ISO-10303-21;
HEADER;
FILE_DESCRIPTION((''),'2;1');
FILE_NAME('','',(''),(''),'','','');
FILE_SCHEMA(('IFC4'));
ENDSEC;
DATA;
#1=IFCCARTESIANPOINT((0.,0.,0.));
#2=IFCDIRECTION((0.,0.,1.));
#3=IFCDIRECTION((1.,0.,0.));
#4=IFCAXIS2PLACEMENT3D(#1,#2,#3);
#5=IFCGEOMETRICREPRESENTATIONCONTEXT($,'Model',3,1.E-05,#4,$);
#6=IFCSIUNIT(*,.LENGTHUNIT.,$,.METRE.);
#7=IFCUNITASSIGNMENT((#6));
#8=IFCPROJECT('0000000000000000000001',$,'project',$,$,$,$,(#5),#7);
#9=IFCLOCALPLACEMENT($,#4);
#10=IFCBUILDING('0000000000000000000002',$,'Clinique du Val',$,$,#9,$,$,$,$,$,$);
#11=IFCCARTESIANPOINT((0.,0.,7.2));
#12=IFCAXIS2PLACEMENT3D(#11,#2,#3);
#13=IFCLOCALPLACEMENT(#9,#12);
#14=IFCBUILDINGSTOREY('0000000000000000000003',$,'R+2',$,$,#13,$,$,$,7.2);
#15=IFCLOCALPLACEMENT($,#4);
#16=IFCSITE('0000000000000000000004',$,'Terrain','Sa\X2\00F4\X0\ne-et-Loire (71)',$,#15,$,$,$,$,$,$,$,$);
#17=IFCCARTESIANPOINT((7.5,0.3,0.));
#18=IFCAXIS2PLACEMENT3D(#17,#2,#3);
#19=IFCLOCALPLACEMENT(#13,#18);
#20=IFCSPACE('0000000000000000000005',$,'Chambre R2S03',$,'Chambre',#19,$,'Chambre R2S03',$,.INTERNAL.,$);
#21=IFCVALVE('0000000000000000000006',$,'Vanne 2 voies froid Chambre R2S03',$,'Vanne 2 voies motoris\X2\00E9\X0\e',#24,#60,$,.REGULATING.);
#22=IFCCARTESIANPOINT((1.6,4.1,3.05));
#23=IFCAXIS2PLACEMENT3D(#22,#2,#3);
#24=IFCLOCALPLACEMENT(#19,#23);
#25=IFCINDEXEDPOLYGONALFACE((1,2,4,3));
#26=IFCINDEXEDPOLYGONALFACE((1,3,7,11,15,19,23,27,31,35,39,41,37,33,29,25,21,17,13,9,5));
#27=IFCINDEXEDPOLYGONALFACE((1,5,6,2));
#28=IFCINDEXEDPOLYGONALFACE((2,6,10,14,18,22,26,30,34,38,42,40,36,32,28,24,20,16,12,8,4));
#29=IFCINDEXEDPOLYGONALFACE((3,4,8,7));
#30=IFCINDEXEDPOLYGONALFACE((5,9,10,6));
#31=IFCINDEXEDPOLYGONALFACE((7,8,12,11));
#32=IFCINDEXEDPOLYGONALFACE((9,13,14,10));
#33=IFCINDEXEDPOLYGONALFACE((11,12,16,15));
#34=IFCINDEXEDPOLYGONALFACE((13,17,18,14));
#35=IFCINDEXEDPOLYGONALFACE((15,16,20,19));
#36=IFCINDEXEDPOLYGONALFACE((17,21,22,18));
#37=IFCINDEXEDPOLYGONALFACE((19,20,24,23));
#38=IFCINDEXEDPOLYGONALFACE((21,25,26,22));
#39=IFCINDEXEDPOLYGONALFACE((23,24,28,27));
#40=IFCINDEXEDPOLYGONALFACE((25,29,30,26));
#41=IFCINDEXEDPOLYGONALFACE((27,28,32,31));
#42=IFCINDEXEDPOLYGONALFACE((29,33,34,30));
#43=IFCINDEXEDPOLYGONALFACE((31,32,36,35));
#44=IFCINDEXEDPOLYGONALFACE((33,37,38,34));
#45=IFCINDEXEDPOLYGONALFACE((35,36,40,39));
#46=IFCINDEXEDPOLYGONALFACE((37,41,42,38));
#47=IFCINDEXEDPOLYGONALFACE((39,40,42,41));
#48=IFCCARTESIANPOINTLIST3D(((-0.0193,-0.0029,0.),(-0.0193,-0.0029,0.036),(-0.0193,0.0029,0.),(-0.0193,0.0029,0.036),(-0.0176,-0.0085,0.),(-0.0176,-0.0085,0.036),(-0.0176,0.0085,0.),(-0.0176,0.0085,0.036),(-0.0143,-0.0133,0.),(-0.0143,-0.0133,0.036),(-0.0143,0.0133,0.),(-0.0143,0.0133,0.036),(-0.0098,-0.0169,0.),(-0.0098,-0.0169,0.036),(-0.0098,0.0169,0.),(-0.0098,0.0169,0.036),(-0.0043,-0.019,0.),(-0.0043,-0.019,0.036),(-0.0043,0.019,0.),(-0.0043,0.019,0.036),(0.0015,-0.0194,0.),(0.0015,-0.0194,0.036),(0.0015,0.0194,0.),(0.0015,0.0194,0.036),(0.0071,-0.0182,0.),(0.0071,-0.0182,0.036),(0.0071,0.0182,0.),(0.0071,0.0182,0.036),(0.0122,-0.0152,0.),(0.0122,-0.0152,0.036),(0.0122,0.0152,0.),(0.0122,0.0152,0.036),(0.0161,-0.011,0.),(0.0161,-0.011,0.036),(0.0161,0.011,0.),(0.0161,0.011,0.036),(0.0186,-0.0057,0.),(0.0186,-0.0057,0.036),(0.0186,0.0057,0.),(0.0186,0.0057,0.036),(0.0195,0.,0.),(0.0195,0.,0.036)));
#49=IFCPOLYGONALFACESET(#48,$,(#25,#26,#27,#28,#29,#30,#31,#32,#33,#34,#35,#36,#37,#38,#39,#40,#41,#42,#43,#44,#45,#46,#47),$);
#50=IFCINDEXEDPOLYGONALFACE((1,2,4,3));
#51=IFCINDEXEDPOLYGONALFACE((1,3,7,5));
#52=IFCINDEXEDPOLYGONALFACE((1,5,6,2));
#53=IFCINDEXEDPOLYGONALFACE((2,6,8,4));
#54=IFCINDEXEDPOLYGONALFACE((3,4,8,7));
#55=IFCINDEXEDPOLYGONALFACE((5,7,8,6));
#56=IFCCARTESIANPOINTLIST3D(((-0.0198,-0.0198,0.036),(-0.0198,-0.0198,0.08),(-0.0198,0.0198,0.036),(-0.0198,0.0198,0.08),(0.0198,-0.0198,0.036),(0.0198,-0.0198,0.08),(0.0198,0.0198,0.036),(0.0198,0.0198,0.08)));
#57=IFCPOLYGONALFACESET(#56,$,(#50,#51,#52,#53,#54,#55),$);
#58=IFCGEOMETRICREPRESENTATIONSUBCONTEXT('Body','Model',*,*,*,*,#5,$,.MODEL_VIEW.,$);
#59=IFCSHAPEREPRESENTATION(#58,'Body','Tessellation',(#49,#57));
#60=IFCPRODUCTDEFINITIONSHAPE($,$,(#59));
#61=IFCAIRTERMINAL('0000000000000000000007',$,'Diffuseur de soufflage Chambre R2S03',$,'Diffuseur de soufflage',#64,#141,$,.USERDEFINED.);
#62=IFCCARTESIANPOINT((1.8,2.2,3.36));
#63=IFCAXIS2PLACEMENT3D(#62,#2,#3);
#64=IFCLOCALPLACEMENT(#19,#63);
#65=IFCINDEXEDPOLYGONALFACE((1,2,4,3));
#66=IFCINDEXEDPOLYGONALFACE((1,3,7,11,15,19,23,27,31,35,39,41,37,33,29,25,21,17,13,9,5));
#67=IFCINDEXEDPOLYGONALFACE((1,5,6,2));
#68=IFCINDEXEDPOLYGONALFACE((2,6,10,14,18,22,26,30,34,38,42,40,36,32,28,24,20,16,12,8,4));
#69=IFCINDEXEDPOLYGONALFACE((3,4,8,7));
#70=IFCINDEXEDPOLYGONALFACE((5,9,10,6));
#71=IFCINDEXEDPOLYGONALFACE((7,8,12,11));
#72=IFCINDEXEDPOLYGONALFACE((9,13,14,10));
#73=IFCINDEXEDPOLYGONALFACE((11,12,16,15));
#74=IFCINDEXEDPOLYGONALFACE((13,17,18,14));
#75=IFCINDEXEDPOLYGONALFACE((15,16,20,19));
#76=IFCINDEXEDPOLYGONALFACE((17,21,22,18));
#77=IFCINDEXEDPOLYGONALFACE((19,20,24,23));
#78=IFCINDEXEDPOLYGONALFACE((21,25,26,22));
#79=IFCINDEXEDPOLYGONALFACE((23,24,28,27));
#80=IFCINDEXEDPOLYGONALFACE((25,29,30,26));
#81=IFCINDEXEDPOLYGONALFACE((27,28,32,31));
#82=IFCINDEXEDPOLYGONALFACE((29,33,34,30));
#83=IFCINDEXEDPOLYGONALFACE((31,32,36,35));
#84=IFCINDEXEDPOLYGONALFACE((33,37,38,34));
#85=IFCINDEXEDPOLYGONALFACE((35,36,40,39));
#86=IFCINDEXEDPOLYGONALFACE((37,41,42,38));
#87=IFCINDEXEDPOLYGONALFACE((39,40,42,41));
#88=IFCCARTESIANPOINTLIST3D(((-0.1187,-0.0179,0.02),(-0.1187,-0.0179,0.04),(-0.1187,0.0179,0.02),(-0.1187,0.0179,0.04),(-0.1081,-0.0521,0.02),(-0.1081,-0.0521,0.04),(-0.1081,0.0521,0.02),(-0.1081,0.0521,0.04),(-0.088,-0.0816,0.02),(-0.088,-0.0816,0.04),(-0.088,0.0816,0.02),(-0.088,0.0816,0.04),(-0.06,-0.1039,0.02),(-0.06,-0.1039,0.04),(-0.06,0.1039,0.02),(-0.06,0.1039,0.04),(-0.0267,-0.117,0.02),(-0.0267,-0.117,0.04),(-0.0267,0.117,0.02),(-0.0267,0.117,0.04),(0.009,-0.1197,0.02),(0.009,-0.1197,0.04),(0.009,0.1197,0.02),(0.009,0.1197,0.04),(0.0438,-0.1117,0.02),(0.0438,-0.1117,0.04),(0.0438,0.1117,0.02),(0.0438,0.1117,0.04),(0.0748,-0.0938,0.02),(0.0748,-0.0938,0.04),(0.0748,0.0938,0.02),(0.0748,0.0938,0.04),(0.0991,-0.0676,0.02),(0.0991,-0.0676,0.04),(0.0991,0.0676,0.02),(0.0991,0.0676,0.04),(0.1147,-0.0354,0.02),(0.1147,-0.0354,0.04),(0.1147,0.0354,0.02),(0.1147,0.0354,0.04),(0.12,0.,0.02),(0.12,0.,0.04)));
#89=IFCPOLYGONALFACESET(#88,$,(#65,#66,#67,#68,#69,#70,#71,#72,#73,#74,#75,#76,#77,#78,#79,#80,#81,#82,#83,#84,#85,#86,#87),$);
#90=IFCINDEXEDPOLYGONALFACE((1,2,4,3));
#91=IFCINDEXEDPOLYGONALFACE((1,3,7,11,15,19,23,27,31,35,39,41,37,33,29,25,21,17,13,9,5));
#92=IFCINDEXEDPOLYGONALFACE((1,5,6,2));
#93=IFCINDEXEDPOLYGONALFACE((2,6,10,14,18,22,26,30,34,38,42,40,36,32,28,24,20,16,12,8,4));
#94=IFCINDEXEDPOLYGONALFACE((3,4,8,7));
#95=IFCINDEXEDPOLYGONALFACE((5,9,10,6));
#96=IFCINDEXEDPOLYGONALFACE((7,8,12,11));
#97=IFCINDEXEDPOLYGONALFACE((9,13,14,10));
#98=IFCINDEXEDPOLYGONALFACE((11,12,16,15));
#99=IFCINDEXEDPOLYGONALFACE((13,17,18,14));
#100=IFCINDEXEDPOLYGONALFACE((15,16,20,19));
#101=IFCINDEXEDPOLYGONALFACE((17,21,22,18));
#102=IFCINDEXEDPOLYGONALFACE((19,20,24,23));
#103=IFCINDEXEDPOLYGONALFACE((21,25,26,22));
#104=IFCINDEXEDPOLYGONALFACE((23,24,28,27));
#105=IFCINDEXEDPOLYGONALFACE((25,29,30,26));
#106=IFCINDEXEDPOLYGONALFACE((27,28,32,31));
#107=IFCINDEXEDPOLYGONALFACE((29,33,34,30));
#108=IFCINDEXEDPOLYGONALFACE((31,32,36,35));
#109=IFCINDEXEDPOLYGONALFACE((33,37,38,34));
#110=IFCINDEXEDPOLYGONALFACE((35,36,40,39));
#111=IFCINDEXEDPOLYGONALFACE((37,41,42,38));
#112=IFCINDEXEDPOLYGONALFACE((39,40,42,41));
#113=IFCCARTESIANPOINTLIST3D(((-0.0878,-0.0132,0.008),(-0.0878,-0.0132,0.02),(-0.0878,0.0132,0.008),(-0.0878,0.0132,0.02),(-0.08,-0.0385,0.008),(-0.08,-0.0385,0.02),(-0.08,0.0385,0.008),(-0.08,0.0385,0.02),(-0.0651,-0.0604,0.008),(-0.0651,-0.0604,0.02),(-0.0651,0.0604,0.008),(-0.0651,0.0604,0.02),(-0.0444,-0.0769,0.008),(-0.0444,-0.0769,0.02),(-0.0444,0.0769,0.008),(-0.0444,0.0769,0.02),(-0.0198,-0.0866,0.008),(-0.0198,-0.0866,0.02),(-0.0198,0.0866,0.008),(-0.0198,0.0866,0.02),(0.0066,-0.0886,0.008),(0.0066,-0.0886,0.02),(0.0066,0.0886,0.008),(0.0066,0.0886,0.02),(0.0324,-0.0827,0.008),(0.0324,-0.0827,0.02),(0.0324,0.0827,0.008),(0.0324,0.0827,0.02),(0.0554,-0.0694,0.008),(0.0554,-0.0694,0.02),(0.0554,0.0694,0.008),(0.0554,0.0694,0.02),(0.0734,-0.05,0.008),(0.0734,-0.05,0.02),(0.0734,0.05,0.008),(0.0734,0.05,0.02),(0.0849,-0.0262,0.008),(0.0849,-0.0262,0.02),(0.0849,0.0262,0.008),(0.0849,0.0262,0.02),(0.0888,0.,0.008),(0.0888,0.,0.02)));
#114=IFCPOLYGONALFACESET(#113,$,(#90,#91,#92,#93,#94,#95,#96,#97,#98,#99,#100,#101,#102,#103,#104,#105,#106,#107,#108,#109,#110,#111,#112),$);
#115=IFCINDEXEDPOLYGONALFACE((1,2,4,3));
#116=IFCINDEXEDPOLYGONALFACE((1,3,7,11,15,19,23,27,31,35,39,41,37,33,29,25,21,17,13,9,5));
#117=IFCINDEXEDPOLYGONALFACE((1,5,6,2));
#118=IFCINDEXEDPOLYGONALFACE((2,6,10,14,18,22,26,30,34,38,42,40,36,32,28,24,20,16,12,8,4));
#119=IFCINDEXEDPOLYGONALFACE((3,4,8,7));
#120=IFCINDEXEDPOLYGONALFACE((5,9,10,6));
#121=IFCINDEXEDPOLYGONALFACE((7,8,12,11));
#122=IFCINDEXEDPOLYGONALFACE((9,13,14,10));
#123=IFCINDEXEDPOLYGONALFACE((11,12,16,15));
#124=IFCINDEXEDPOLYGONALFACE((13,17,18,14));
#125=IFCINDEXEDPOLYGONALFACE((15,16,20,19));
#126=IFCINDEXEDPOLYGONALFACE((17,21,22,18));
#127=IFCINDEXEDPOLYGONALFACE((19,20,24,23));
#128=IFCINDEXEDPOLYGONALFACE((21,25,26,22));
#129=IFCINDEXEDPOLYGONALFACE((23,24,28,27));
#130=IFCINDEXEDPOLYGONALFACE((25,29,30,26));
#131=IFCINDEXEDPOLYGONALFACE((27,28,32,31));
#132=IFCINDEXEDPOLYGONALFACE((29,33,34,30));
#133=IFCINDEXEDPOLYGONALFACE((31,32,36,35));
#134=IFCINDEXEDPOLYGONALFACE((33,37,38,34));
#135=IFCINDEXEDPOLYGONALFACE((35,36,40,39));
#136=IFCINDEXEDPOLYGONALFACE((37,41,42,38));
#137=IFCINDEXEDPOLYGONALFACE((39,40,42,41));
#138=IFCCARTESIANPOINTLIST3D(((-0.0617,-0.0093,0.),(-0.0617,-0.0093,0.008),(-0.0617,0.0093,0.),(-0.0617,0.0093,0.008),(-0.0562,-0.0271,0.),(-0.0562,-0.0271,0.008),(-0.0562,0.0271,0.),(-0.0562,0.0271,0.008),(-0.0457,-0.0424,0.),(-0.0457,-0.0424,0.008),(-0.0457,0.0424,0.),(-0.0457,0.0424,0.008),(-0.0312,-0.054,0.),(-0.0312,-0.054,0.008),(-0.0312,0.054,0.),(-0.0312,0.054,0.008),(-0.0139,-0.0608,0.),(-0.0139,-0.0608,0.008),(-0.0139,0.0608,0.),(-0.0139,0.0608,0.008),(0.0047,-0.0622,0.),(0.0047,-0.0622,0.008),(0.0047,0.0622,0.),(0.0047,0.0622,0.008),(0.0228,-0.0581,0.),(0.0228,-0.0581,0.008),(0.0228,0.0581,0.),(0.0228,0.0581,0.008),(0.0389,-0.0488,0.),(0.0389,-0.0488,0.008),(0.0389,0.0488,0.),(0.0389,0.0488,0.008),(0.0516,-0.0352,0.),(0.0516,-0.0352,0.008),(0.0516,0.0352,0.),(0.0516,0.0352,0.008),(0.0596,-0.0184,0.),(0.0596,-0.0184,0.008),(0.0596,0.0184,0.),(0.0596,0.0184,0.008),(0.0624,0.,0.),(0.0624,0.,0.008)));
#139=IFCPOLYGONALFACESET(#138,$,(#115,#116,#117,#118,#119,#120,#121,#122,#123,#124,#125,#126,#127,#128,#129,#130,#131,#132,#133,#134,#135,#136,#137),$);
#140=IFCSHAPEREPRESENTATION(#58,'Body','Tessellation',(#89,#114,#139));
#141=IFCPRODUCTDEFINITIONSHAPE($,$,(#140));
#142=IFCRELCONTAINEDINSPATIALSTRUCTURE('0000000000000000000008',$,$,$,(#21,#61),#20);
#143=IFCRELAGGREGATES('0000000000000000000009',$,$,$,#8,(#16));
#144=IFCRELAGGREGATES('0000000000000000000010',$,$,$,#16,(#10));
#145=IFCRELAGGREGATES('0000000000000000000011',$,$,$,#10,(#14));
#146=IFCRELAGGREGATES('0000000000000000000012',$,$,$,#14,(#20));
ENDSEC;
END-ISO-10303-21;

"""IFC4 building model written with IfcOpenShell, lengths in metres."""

from ifc_helpers import new_model, si_unit, frame, frame_2d, origin_with_axes, place, context, subcontext, project, spatial, rectangle, circle, extrude, element, save


model = new_model("IFC4")

# Units and contexts
model_context = context("Model", 3, precision=1e-05, world=origin_with_axes())
body_context = subcontext(model_context, "Body", "Model", "MODEL_VIEW")
ifc_project = project(units=[si_unit("LENGTHUNIT", "METRE")], contexts=[model_context])

# Site, building, storey
site_placement = place(None, origin_with_axes())
site = spatial("IfcSite", under=ifc_project, at=site_placement, Name="Terrain", Description="Saône-et-Loire (71)")
building_placement = place(None, origin_with_axes())
building = spatial("IfcBuilding", under=site, at=building_placement, Name="Clinique du Val")
storey_placement = place(building_placement, frame((0.0, 0.0, 7.2), z_axis=(0.0, 0.0, 1.0), x_axis=(1.0, 0.0, 0.0)))
storey = spatial("IfcBuildingStorey", under=building, at=storey_placement, Name="R+2", Elevation=7.2)

# Shared definitions
space_1_placement = place(storey_placement, frame((7.5, 0.3, 0.0), z_axis=(0.0, 0.0, 1.0), x_axis=(1.0, 0.0, 0.0)))
space_1 = spatial("IfcSpace", under=storey, at=space_1_placement, Name="Chambre R2S03", ObjectType="Chambre", LongName="Chambre R2S03", PredefinedType="INTERNAL")

# Valve
for number, where, z_axis, x_axis, name in (
    (1, (1.6, 4.1, 3.05), (0.0, 0.0, 1.0), (1.0, 0.0, 0.0), "Vanne 2 voies froid Chambre R2S03"),
):
    element("IfcValve", number, at=place(space_1_placement, frame(where, z_axis=z_axis, x_axis=x_axis)), inside=space_1, Name=name, ObjectType="Vanne 2 voies motorisée", PredefinedType="REGULATING", context=body_context, shape_type="SweptSolid", body=[
        extrude(circle(Radius=0.0195), origin_with_axes(), (0.0, 0.0, 1.0), 0.036),
        extrude(rectangle(XDim=0.0396, YDim=0.0396, at=frame_2d((0.0198, 0.0198))), frame((-0.0198, -0.0198, 0.036), z_axis=(0.0, 0.0, 1.0), x_axis=(1.0, 0.0, 0.0)), (0.0, 0.0, 1.0), 0.044),
    ])

# Air terminal
air_terminal_1_placement = place(space_1_placement, frame((1.8, 2.2, 3.36), z_axis=(0.0, 0.0, 1.0), x_axis=(1.0, 0.0, 0.0)))
element("IfcAirTerminal", 2, at=air_terminal_1_placement, inside=space_1, Name="Diffuseur de soufflage Chambre R2S03", ObjectType="Diffuseur de soufflage", PredefinedType="USERDEFINED", context=body_context, shape_type="SweptSolid", body=[
    extrude(circle(Radius=0.12), frame((0.0, 0.0, 0.02), z_axis=(0.0, 0.0, 1.0), x_axis=(1.0, 0.0, 0.0)), (0.0, 0.0, 1.0), 0.02),
    extrude(circle(Radius=0.0888), frame((0.0, 0.0, 0.008), z_axis=(0.0, 0.0, 1.0), x_axis=(1.0, 0.0, 0.0)), (0.0, 0.0, 1.0), 0.012),
    extrude(circle(Radius=0.0624), origin_with_axes(), (0.0, 0.0, 1.0), 0.008),
])

save(model, "model.ifc")
